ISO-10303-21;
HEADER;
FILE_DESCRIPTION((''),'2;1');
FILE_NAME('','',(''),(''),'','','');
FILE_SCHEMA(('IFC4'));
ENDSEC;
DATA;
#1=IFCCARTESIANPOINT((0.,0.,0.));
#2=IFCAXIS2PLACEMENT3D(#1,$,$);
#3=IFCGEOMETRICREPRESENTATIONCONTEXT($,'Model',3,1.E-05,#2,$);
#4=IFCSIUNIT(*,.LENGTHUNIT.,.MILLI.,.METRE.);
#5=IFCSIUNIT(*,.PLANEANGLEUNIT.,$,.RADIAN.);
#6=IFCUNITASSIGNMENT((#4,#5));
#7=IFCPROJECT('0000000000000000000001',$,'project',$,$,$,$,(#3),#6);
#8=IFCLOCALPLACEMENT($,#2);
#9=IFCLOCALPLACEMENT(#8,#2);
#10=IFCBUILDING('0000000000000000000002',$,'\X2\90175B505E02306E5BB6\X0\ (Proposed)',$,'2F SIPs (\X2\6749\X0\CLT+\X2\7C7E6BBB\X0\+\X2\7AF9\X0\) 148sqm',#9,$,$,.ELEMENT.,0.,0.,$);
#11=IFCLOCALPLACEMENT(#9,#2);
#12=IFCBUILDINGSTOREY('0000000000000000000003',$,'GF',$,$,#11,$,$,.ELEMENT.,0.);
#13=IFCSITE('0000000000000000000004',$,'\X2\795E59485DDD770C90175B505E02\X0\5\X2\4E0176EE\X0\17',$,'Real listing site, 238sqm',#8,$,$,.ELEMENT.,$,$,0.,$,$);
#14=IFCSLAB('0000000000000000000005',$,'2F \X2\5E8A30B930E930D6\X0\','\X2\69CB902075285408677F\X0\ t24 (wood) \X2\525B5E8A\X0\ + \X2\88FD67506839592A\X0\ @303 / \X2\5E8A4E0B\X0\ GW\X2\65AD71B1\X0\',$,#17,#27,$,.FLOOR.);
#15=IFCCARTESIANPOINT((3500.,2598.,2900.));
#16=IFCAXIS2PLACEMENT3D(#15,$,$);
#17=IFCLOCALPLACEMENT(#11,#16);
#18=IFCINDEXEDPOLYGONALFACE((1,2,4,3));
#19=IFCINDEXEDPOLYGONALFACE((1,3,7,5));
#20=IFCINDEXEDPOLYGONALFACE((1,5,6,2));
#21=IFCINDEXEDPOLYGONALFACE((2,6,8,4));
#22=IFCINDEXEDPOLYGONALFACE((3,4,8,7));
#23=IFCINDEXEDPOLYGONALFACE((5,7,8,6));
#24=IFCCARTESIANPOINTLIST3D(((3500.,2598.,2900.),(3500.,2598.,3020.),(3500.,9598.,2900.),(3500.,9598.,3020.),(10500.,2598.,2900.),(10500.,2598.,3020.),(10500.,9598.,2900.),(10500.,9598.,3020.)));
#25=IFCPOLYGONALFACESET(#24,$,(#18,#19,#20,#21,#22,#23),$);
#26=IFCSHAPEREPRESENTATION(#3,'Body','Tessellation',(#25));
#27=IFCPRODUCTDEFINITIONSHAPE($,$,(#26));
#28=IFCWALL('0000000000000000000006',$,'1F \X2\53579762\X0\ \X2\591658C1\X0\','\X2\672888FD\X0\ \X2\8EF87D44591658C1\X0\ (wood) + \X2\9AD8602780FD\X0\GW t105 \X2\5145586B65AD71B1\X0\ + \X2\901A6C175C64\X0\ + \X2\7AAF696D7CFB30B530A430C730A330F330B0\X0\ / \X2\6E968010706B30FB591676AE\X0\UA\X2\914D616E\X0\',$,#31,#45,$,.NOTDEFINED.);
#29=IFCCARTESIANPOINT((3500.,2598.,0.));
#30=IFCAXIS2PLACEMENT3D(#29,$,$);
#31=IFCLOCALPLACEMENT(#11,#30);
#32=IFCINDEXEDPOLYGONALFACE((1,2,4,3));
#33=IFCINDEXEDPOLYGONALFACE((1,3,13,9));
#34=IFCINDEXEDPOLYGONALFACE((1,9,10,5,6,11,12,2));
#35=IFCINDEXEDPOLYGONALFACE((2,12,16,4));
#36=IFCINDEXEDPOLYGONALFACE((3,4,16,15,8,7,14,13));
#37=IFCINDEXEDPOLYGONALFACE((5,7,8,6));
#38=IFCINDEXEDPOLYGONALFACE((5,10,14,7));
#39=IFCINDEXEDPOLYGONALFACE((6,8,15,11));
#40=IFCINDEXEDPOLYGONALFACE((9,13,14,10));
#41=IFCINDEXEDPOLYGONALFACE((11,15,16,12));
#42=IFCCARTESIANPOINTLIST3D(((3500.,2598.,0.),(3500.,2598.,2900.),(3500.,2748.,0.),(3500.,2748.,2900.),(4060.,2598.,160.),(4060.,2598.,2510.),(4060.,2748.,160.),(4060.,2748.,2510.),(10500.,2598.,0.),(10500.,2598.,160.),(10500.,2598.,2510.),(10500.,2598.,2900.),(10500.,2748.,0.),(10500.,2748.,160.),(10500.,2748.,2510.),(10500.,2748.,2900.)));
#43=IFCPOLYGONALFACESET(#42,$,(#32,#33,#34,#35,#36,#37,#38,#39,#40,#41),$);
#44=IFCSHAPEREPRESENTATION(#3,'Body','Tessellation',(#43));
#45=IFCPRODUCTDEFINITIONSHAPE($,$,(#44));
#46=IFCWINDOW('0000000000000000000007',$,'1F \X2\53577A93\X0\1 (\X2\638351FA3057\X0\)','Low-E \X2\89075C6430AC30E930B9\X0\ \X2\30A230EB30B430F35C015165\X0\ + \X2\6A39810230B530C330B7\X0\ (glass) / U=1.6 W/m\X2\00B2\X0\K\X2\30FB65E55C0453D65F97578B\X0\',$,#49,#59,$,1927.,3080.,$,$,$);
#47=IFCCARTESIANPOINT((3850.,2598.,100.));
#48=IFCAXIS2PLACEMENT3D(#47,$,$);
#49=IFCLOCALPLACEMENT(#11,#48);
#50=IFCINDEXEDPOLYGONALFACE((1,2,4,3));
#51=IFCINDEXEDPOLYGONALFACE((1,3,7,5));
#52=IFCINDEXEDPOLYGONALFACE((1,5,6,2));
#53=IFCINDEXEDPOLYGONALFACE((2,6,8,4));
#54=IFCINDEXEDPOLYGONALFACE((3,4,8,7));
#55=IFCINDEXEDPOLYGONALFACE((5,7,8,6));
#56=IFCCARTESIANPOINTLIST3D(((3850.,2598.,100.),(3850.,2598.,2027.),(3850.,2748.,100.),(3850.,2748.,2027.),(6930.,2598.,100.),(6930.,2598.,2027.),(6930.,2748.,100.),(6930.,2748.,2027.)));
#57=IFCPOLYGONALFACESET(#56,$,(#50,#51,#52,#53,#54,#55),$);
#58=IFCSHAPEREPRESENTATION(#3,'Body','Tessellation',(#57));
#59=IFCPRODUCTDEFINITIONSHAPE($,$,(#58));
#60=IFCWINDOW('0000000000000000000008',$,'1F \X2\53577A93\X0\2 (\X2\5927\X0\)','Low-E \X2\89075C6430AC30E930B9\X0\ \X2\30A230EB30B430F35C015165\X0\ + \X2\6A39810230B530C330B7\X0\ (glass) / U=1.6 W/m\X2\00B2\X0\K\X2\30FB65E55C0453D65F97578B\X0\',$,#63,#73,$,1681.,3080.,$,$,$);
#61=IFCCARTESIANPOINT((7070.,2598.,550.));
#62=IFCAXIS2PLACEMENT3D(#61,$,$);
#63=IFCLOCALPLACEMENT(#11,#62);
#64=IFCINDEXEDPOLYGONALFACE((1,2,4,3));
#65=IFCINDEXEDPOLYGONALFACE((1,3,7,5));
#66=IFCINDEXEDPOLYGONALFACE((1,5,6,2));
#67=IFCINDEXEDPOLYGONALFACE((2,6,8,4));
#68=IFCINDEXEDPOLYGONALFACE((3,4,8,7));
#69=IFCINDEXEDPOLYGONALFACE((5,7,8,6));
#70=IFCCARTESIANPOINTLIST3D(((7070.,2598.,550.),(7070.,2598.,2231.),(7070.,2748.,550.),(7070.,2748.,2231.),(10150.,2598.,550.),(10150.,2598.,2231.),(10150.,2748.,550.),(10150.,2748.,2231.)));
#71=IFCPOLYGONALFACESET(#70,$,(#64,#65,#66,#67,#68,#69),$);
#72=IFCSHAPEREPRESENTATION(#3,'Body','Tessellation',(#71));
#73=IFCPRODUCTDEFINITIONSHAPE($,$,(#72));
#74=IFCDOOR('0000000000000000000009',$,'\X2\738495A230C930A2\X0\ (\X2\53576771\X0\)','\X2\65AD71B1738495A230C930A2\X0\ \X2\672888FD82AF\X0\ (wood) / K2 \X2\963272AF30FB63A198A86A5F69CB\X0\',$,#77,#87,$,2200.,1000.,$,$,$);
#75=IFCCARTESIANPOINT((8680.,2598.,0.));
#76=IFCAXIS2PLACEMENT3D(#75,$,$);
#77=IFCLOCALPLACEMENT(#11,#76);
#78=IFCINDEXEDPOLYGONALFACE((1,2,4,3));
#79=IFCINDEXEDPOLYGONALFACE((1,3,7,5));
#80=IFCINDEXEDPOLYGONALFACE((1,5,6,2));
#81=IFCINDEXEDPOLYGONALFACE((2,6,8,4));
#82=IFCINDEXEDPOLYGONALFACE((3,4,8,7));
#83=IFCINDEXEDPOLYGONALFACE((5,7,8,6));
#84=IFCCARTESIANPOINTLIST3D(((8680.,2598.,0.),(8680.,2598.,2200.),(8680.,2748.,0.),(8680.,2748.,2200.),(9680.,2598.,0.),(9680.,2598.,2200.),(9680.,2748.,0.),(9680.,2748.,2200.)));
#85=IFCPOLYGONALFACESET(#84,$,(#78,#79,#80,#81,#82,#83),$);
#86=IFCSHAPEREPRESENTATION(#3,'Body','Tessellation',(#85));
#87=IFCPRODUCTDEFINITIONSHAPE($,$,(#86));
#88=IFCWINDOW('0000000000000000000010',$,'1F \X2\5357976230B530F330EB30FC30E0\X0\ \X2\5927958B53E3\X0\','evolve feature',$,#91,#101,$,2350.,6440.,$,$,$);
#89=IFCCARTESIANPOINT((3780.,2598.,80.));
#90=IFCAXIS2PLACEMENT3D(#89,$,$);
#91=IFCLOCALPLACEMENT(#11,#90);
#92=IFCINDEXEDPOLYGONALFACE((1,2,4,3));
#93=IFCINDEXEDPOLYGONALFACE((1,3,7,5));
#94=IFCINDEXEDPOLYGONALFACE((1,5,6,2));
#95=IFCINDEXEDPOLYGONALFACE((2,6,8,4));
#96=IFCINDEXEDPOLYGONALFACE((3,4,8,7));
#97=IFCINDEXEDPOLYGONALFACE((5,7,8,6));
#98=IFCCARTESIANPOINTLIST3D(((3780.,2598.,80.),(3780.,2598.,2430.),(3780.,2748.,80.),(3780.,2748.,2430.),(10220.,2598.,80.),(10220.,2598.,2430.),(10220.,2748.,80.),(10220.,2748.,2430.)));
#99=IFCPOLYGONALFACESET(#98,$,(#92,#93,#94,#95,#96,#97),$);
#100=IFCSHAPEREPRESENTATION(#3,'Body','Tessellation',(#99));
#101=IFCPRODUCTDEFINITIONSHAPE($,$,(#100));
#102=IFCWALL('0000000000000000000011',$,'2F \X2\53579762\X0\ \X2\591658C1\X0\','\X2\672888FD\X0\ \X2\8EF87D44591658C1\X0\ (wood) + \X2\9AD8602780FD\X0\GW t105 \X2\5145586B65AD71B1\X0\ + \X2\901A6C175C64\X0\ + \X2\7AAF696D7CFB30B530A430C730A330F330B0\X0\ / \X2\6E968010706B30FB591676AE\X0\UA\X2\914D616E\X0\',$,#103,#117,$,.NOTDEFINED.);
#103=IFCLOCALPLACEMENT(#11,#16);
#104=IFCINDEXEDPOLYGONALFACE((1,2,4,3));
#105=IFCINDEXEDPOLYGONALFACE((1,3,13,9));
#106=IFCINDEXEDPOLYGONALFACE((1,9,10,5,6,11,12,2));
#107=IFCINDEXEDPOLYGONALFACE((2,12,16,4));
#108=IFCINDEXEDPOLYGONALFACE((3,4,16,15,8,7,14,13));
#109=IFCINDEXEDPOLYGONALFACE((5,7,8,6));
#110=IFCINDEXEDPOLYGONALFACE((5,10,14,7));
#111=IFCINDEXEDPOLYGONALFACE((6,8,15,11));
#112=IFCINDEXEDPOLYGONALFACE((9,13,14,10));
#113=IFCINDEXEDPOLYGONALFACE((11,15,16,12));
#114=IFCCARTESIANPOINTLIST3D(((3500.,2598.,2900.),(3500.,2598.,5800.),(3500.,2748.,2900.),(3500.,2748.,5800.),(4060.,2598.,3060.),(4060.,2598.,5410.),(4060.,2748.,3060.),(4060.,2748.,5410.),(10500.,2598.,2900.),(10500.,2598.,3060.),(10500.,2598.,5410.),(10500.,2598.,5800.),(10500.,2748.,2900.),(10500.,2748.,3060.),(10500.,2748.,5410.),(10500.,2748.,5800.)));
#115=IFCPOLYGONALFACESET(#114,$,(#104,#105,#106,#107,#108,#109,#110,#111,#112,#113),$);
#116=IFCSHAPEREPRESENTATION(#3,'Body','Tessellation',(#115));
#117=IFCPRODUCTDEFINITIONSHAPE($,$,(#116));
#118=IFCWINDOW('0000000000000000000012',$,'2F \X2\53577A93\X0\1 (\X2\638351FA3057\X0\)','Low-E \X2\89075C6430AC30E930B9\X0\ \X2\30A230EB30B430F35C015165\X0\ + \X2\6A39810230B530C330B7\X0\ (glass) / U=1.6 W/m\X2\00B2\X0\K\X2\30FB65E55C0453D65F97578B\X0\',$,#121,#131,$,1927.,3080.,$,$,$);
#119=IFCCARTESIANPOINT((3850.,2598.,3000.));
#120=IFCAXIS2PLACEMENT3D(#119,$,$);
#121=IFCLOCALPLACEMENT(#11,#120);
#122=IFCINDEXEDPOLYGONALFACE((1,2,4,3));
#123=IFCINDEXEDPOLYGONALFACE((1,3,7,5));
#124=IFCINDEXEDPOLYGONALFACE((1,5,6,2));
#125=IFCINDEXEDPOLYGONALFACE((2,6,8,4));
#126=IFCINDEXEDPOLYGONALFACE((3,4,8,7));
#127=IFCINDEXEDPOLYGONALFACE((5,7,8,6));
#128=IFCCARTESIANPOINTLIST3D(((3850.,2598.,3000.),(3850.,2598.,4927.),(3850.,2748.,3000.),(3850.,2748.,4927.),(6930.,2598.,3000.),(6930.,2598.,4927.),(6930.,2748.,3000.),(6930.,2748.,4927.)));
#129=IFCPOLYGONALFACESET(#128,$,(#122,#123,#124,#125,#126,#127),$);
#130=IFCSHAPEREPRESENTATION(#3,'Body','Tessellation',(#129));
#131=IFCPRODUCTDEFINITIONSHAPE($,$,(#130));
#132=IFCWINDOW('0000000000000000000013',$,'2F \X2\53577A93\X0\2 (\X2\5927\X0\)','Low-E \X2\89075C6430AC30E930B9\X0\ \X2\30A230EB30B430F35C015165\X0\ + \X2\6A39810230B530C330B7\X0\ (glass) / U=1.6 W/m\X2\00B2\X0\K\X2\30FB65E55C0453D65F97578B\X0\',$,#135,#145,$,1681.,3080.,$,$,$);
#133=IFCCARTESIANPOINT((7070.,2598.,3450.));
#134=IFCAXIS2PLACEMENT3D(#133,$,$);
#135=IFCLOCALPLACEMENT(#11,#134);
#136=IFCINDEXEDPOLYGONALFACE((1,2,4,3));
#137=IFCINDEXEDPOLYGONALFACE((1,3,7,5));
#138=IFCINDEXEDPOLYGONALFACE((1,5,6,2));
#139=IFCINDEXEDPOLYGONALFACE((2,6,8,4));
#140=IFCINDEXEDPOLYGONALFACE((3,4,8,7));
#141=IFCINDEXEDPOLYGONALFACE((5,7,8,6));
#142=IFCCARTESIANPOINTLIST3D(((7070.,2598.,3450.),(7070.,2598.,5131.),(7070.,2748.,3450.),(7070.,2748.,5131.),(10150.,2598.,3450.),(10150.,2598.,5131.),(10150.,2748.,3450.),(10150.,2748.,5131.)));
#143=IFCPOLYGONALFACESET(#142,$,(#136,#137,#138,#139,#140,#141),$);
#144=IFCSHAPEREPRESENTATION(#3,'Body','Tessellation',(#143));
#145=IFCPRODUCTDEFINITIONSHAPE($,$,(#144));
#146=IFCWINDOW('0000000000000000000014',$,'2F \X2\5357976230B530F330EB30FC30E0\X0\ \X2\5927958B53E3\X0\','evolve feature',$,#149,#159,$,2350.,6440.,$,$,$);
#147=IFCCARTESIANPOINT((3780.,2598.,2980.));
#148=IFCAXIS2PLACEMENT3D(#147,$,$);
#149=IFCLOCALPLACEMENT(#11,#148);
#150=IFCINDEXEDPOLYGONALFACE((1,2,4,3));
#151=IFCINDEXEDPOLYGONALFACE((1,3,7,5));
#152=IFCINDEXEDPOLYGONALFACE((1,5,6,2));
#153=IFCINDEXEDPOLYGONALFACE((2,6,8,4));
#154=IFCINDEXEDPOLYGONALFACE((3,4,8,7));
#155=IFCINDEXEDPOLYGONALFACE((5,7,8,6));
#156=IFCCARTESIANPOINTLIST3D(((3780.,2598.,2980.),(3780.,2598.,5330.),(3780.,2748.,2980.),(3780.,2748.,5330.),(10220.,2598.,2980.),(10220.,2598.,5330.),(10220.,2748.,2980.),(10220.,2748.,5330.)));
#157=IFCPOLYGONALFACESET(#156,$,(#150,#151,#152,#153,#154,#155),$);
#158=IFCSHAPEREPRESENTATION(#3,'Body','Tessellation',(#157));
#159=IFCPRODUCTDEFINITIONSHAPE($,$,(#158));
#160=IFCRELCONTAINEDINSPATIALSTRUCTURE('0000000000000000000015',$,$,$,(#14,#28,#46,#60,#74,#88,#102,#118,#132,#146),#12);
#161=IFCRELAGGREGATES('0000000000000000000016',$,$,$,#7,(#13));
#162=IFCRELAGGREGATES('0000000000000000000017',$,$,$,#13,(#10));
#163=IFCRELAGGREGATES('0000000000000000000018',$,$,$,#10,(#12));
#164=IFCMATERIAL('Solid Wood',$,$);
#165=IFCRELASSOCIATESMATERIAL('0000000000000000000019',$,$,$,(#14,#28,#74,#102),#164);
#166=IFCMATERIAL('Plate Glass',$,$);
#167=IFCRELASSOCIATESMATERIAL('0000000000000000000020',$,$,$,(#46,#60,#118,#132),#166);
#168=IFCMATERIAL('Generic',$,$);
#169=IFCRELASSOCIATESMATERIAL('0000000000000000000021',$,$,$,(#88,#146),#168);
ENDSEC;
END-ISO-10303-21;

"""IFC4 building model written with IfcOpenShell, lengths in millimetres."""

from ifc_helpers import new_model, si_unit, frame, frame_2d, origin, place, context, project, spatial, rectangle, extrude, material, element, fill, save


model = new_model("IFC4")

# Units and contexts
model_context = context("Model", 3, precision=1e-05, world=origin())
ifc_project = project(units=[si_unit("LENGTHUNIT", "METRE", prefix="MILLI"), si_unit("PLANEANGLEUNIT", "RADIAN")], contexts=[model_context])

# Site, building, storey
site_placement = place(None, origin())
site = spatial("IfcSite", under=ifc_project, at=site_placement, Name="神奈川県逗子市5丁目17", ObjectType="Real listing site, 238sqm", CompositionType="ELEMENT", RefElevation=0.0)
building_placement = place(site_placement, origin())
building = spatial("IfcBuilding", under=site, at=building_placement, Name="逗子市の家 (Proposed)", ObjectType="2F SIPs (杉CLT+籾殻+竹) 148sqm", CompositionType="ELEMENT", ElevationOfRefHeight=0.0, ElevationOfTerrain=0.0)
storey_placement = place(building_placement, origin())
storey = spatial("IfcBuildingStorey", under=building, at=storey_placement, Name="GF", CompositionType="ELEMENT", Elevation=0.0)

# Slab
ifc_material_1 = material(Name="Solid Wood")
slab_1_placement = place(storey_placement, frame((3500.0, 2598.0, 2900.0)))
element("IfcSlab", 1, at=slab_1_placement, inside=storey, material=ifc_material_1, Name="2F 床スラブ", Description="構造用合板 t24 (wood) 剛床 + 製材根太 @303 / 床下 GW断熱", PredefinedType="FLOOR", context=model_context, shape_type="SweptSolid", body=[
    extrude(rectangle(XDim=7000.0, YDim=7000.0, at=frame_2d((3500.0, 3500.0))), frame((3500.0, 2598.0, 2900.0)), (0.0, 0.0, 1.0), 120.0),
])
ifc_material_2 = material(Name="Generic")

# Wall, openings, windows, door
wall_1_placement = place(storey_placement, frame((3500.0, 2598.0, 0.0)))
wall_1 = element("IfcWall", 2, at=wall_1_placement, inside=storey, material=ifc_material_1, Name="1F 南面 外壁", Description="木製 軸組外壁 (wood) + 高性能GW t105 充填断熱 + 通気層 + 窯業系サイディング / 準耐火・外皮UA配慮", PredefinedType="NOTDEFINED", context=model_context, shape_type="SweptSolid", body=[
    extrude(rectangle(XDim=7000.0, YDim=150.0, at=frame_2d((3500.0, 75.0))), frame((3500.0, 2598.0, 0.0)), (0.0, 0.0, 1.0), 2900.0),
])
opening_1_placement = place(storey_placement, frame((3850.0, 2598.0, 100.0)))
opening_1 = element("IfcOpeningElement", 3, at=opening_1_placement, cuts=wall_1, PredefinedType="NOTDEFINED", context=model_context, shape_type="SweptSolid", body=[
    extrude(rectangle(XDim=3080.0, YDim=150.0, at=frame_2d((1540.0, 75.0))), frame((3850.0, 2598.0, 100.0)), (0.0, 0.0, 1.0), 1927.0),
])
opening_2_placement = place(storey_placement, frame((7070.0, 2598.0, 550.0)))
opening_2 = element("IfcOpeningElement", 4, at=opening_2_placement, cuts=wall_1, PredefinedType="NOTDEFINED", context=model_context, shape_type="SweptSolid", body=[
    extrude(rectangle(XDim=3080.0, YDim=150.0, at=frame_2d((1540.0, 75.0))), frame((7070.0, 2598.0, 550.0)), (0.0, 0.0, 1.0), 1681.0),
])
opening_3_placement = place(storey_placement, frame((8680.0, 2598.0, 0.0)))
opening_3 = element("IfcOpeningElement", 5, at=opening_3_placement, cuts=wall_1, PredefinedType="NOTDEFINED", context=model_context, shape_type="SweptSolid", body=[
    extrude(rectangle(XDim=1000.0, YDim=150.0, at=frame_2d((500.0, 75.0))), frame((8680.0, 2598.0, 0.0)), (0.0, 0.0, 1.0), 2200.0),
])
opening_4_placement = place(storey_placement, frame((3780.0, 2598.0, 80.0)))
opening_4 = element("IfcOpeningElement", 6, at=opening_4_placement, cuts=wall_1, PredefinedType="NOTDEFINED", context=model_context, shape_type="SweptSolid", body=[
    extrude(rectangle(XDim=6440.0, YDim=150.0, at=frame_2d((3220.0, 75.0))), frame((3780.0, 2598.0, 80.0)), (0.0, 0.0, 1.0), 2350.0),
])
ifc_material_3 = material(Name="Plate Glass")
window_1_placement = place(storey_placement, frame((3850.0, 2598.0, 100.0)))
window_1 = element("IfcWindow", 7, at=window_1_placement, inside=storey, material=ifc_material_3, Name="1F 南窓1 (掃出し)", Description="Low-E 複層ガラス アルゴン封入 + 樹脂サッシ (glass) / U=1.6 W/m²K・日射取得型", OverallHeight=1927.0, OverallWidth=3080.0, context=model_context, shape_type="SweptSolid", body=[
    extrude(rectangle(XDim=3080.0, YDim=150.0, at=frame_2d((1540.0, 75.0))), frame((3850.0, 2598.0, 100.0)), (0.0, 0.0, 1.0), 1927.0),
])
fill(opening_1, window_1)
window_2_placement = place(storey_placement, frame((7070.0, 2598.0, 550.0)))
window_2 = element("IfcWindow", 8, at=window_2_placement, inside=storey, material=ifc_material_3, Name="1F 南窓2 (大)", Description="Low-E 複層ガラス アルゴン封入 + 樹脂サッシ (glass) / U=1.6 W/m²K・日射取得型", OverallHeight=1681.0, OverallWidth=3080.0, context=model_context, shape_type="SweptSolid", body=[
    extrude(rectangle(XDim=3080.0, YDim=150.0, at=frame_2d((1540.0, 75.0))), frame((7070.0, 2598.0, 550.0)), (0.0, 0.0, 1.0), 1681.0),
])
fill(opening_2, window_2)
door_placement = place(storey_placement, frame((8680.0, 2598.0, 0.0)))
door = element("IfcDoor", 9, at=door_placement, inside=storey, material=ifc_material_1, Name="玄関ドア (南東)", Description="断熱玄関ドア 木製芯 (wood) / K2 防犯・採風機構", OverallHeight=2200.0, OverallWidth=1000.0, context=model_context, shape_type="SweptSolid", body=[
    extrude(rectangle(XDim=1000.0, YDim=150.0, at=frame_2d((500.0, 75.0))), frame((8680.0, 2598.0, 0.0)), (0.0, 0.0, 1.0), 2200.0),
])
fill(opening_3, door)
window_3_placement = place(storey_placement, frame((3780.0, 2598.0, 80.0)))
window_3 = element("IfcWindow", 10, at=window_3_placement, inside=storey, material=ifc_material_2, Name="1F 南面サンルーム 大開口", Description="evolve feature", OverallHeight=2350.0, OverallWidth=6440.0, context=model_context, shape_type="SweptSolid", body=[
    extrude(rectangle(XDim=6440.0, YDim=150.0, at=frame_2d((3220.0, 75.0))), frame((3780.0, 2598.0, 80.0)), (0.0, 0.0, 1.0), 2350.0),
])
fill(opening_4, window_3)

# Wall, openings, windows
wall_2_placement = place(storey_placement, frame((3500.0, 2598.0, 2900.0)))
wall_2 = element("IfcWall", 11, at=wall_2_placement, inside=storey, material=ifc_material_1, Name="2F 南面 外壁", Description="木製 軸組外壁 (wood) + 高性能GW t105 充填断熱 + 通気層 + 窯業系サイディング / 準耐火・外皮UA配慮", PredefinedType="NOTDEFINED", context=model_context, shape_type="SweptSolid", body=[
    extrude(rectangle(XDim=7000.0, YDim=150.0, at=frame_2d((3500.0, 75.0))), frame((3500.0, 2598.0, 2900.0)), (0.0, 0.0, 1.0), 2900.0),
])
opening_5_placement = place(storey_placement, frame((3850.0, 2598.0, 3000.0)))
opening_5 = element("IfcOpeningElement", 12, at=opening_5_placement, cuts=wall_2, PredefinedType="NOTDEFINED", context=model_context, shape_type="SweptSolid", body=[
    extrude(rectangle(XDim=3080.0, YDim=150.0, at=frame_2d((1540.0, 75.0))), frame((3850.0, 2598.0, 3000.0)), (0.0, 0.0, 1.0), 1927.0),
])
opening_6_placement = place(storey_placement, frame((7070.0, 2598.0, 3450.0)))
opening_6 = element("IfcOpeningElement", 13, at=opening_6_placement, cuts=wall_2, PredefinedType="NOTDEFINED", context=model_context, shape_type="SweptSolid", body=[
    extrude(rectangle(XDim=3080.0, YDim=150.0, at=frame_2d((1540.0, 75.0))), frame((7070.0, 2598.0, 3450.0)), (0.0, 0.0, 1.0), 1681.0),
])
opening_7_placement = place(storey_placement, frame((3780.0, 2598.0, 2980.0)))
opening_7 = element("IfcOpeningElement", 14, at=opening_7_placement, cuts=wall_2, PredefinedType="NOTDEFINED", context=model_context, shape_type="SweptSolid", body=[
    extrude(rectangle(XDim=6440.0, YDim=150.0, at=frame_2d((3220.0, 75.0))), frame((3780.0, 2598.0, 2980.0)), (0.0, 0.0, 1.0), 2350.0),
])
window_4_placement = place(storey_placement, frame((3850.0, 2598.0, 3000.0)))
window_4 = element("IfcWindow", 15, at=window_4_placement, inside=storey, material=ifc_material_3, Name="2F 南窓1 (掃出し)", Description="Low-E 複層ガラス アルゴン封入 + 樹脂サッシ (glass) / U=1.6 W/m²K・日射取得型", OverallHeight=1927.0, OverallWidth=3080.0, context=model_context, shape_type="SweptSolid", body=[
    extrude(rectangle(XDim=3080.0, YDim=150.0, at=frame_2d((1540.0, 75.0))), frame((3850.0, 2598.0, 3000.0)), (0.0, 0.0, 1.0), 1927.0),
])
fill(opening_5, window_4)
window_5_placement = place(storey_placement, frame((7070.0, 2598.0, 3450.0)))
window_5 = element("IfcWindow", 16, at=window_5_placement, inside=storey, material=ifc_material_3, Name="2F 南窓2 (大)", Description="Low-E 複層ガラス アルゴン封入 + 樹脂サッシ (glass) / U=1.6 W/m²K・日射取得型", OverallHeight=1681.0, OverallWidth=3080.0, context=model_context, shape_type="SweptSolid", body=[
    extrude(rectangle(XDim=3080.0, YDim=150.0, at=frame_2d((1540.0, 75.0))), frame((7070.0, 2598.0, 3450.0)), (0.0, 0.0, 1.0), 1681.0),
])
fill(opening_6, window_5)
window_6_placement = place(storey_placement, frame((3780.0, 2598.0, 2980.0)))
window_6 = element("IfcWindow", 17, at=window_6_placement, inside=storey, material=ifc_material_2, Name="2F 南面サンルーム 大開口", Description="evolve feature", OverallHeight=2350.0, OverallWidth=6440.0, context=model_context, shape_type="SweptSolid", body=[
    extrude(rectangle(XDim=6440.0, YDim=150.0, at=frame_2d((3220.0, 75.0))), frame((3780.0, 2598.0, 2980.0)), (0.0, 0.0, 1.0), 2350.0),
])
fill(opening_7, window_6)

save(model, "model.ifc")
